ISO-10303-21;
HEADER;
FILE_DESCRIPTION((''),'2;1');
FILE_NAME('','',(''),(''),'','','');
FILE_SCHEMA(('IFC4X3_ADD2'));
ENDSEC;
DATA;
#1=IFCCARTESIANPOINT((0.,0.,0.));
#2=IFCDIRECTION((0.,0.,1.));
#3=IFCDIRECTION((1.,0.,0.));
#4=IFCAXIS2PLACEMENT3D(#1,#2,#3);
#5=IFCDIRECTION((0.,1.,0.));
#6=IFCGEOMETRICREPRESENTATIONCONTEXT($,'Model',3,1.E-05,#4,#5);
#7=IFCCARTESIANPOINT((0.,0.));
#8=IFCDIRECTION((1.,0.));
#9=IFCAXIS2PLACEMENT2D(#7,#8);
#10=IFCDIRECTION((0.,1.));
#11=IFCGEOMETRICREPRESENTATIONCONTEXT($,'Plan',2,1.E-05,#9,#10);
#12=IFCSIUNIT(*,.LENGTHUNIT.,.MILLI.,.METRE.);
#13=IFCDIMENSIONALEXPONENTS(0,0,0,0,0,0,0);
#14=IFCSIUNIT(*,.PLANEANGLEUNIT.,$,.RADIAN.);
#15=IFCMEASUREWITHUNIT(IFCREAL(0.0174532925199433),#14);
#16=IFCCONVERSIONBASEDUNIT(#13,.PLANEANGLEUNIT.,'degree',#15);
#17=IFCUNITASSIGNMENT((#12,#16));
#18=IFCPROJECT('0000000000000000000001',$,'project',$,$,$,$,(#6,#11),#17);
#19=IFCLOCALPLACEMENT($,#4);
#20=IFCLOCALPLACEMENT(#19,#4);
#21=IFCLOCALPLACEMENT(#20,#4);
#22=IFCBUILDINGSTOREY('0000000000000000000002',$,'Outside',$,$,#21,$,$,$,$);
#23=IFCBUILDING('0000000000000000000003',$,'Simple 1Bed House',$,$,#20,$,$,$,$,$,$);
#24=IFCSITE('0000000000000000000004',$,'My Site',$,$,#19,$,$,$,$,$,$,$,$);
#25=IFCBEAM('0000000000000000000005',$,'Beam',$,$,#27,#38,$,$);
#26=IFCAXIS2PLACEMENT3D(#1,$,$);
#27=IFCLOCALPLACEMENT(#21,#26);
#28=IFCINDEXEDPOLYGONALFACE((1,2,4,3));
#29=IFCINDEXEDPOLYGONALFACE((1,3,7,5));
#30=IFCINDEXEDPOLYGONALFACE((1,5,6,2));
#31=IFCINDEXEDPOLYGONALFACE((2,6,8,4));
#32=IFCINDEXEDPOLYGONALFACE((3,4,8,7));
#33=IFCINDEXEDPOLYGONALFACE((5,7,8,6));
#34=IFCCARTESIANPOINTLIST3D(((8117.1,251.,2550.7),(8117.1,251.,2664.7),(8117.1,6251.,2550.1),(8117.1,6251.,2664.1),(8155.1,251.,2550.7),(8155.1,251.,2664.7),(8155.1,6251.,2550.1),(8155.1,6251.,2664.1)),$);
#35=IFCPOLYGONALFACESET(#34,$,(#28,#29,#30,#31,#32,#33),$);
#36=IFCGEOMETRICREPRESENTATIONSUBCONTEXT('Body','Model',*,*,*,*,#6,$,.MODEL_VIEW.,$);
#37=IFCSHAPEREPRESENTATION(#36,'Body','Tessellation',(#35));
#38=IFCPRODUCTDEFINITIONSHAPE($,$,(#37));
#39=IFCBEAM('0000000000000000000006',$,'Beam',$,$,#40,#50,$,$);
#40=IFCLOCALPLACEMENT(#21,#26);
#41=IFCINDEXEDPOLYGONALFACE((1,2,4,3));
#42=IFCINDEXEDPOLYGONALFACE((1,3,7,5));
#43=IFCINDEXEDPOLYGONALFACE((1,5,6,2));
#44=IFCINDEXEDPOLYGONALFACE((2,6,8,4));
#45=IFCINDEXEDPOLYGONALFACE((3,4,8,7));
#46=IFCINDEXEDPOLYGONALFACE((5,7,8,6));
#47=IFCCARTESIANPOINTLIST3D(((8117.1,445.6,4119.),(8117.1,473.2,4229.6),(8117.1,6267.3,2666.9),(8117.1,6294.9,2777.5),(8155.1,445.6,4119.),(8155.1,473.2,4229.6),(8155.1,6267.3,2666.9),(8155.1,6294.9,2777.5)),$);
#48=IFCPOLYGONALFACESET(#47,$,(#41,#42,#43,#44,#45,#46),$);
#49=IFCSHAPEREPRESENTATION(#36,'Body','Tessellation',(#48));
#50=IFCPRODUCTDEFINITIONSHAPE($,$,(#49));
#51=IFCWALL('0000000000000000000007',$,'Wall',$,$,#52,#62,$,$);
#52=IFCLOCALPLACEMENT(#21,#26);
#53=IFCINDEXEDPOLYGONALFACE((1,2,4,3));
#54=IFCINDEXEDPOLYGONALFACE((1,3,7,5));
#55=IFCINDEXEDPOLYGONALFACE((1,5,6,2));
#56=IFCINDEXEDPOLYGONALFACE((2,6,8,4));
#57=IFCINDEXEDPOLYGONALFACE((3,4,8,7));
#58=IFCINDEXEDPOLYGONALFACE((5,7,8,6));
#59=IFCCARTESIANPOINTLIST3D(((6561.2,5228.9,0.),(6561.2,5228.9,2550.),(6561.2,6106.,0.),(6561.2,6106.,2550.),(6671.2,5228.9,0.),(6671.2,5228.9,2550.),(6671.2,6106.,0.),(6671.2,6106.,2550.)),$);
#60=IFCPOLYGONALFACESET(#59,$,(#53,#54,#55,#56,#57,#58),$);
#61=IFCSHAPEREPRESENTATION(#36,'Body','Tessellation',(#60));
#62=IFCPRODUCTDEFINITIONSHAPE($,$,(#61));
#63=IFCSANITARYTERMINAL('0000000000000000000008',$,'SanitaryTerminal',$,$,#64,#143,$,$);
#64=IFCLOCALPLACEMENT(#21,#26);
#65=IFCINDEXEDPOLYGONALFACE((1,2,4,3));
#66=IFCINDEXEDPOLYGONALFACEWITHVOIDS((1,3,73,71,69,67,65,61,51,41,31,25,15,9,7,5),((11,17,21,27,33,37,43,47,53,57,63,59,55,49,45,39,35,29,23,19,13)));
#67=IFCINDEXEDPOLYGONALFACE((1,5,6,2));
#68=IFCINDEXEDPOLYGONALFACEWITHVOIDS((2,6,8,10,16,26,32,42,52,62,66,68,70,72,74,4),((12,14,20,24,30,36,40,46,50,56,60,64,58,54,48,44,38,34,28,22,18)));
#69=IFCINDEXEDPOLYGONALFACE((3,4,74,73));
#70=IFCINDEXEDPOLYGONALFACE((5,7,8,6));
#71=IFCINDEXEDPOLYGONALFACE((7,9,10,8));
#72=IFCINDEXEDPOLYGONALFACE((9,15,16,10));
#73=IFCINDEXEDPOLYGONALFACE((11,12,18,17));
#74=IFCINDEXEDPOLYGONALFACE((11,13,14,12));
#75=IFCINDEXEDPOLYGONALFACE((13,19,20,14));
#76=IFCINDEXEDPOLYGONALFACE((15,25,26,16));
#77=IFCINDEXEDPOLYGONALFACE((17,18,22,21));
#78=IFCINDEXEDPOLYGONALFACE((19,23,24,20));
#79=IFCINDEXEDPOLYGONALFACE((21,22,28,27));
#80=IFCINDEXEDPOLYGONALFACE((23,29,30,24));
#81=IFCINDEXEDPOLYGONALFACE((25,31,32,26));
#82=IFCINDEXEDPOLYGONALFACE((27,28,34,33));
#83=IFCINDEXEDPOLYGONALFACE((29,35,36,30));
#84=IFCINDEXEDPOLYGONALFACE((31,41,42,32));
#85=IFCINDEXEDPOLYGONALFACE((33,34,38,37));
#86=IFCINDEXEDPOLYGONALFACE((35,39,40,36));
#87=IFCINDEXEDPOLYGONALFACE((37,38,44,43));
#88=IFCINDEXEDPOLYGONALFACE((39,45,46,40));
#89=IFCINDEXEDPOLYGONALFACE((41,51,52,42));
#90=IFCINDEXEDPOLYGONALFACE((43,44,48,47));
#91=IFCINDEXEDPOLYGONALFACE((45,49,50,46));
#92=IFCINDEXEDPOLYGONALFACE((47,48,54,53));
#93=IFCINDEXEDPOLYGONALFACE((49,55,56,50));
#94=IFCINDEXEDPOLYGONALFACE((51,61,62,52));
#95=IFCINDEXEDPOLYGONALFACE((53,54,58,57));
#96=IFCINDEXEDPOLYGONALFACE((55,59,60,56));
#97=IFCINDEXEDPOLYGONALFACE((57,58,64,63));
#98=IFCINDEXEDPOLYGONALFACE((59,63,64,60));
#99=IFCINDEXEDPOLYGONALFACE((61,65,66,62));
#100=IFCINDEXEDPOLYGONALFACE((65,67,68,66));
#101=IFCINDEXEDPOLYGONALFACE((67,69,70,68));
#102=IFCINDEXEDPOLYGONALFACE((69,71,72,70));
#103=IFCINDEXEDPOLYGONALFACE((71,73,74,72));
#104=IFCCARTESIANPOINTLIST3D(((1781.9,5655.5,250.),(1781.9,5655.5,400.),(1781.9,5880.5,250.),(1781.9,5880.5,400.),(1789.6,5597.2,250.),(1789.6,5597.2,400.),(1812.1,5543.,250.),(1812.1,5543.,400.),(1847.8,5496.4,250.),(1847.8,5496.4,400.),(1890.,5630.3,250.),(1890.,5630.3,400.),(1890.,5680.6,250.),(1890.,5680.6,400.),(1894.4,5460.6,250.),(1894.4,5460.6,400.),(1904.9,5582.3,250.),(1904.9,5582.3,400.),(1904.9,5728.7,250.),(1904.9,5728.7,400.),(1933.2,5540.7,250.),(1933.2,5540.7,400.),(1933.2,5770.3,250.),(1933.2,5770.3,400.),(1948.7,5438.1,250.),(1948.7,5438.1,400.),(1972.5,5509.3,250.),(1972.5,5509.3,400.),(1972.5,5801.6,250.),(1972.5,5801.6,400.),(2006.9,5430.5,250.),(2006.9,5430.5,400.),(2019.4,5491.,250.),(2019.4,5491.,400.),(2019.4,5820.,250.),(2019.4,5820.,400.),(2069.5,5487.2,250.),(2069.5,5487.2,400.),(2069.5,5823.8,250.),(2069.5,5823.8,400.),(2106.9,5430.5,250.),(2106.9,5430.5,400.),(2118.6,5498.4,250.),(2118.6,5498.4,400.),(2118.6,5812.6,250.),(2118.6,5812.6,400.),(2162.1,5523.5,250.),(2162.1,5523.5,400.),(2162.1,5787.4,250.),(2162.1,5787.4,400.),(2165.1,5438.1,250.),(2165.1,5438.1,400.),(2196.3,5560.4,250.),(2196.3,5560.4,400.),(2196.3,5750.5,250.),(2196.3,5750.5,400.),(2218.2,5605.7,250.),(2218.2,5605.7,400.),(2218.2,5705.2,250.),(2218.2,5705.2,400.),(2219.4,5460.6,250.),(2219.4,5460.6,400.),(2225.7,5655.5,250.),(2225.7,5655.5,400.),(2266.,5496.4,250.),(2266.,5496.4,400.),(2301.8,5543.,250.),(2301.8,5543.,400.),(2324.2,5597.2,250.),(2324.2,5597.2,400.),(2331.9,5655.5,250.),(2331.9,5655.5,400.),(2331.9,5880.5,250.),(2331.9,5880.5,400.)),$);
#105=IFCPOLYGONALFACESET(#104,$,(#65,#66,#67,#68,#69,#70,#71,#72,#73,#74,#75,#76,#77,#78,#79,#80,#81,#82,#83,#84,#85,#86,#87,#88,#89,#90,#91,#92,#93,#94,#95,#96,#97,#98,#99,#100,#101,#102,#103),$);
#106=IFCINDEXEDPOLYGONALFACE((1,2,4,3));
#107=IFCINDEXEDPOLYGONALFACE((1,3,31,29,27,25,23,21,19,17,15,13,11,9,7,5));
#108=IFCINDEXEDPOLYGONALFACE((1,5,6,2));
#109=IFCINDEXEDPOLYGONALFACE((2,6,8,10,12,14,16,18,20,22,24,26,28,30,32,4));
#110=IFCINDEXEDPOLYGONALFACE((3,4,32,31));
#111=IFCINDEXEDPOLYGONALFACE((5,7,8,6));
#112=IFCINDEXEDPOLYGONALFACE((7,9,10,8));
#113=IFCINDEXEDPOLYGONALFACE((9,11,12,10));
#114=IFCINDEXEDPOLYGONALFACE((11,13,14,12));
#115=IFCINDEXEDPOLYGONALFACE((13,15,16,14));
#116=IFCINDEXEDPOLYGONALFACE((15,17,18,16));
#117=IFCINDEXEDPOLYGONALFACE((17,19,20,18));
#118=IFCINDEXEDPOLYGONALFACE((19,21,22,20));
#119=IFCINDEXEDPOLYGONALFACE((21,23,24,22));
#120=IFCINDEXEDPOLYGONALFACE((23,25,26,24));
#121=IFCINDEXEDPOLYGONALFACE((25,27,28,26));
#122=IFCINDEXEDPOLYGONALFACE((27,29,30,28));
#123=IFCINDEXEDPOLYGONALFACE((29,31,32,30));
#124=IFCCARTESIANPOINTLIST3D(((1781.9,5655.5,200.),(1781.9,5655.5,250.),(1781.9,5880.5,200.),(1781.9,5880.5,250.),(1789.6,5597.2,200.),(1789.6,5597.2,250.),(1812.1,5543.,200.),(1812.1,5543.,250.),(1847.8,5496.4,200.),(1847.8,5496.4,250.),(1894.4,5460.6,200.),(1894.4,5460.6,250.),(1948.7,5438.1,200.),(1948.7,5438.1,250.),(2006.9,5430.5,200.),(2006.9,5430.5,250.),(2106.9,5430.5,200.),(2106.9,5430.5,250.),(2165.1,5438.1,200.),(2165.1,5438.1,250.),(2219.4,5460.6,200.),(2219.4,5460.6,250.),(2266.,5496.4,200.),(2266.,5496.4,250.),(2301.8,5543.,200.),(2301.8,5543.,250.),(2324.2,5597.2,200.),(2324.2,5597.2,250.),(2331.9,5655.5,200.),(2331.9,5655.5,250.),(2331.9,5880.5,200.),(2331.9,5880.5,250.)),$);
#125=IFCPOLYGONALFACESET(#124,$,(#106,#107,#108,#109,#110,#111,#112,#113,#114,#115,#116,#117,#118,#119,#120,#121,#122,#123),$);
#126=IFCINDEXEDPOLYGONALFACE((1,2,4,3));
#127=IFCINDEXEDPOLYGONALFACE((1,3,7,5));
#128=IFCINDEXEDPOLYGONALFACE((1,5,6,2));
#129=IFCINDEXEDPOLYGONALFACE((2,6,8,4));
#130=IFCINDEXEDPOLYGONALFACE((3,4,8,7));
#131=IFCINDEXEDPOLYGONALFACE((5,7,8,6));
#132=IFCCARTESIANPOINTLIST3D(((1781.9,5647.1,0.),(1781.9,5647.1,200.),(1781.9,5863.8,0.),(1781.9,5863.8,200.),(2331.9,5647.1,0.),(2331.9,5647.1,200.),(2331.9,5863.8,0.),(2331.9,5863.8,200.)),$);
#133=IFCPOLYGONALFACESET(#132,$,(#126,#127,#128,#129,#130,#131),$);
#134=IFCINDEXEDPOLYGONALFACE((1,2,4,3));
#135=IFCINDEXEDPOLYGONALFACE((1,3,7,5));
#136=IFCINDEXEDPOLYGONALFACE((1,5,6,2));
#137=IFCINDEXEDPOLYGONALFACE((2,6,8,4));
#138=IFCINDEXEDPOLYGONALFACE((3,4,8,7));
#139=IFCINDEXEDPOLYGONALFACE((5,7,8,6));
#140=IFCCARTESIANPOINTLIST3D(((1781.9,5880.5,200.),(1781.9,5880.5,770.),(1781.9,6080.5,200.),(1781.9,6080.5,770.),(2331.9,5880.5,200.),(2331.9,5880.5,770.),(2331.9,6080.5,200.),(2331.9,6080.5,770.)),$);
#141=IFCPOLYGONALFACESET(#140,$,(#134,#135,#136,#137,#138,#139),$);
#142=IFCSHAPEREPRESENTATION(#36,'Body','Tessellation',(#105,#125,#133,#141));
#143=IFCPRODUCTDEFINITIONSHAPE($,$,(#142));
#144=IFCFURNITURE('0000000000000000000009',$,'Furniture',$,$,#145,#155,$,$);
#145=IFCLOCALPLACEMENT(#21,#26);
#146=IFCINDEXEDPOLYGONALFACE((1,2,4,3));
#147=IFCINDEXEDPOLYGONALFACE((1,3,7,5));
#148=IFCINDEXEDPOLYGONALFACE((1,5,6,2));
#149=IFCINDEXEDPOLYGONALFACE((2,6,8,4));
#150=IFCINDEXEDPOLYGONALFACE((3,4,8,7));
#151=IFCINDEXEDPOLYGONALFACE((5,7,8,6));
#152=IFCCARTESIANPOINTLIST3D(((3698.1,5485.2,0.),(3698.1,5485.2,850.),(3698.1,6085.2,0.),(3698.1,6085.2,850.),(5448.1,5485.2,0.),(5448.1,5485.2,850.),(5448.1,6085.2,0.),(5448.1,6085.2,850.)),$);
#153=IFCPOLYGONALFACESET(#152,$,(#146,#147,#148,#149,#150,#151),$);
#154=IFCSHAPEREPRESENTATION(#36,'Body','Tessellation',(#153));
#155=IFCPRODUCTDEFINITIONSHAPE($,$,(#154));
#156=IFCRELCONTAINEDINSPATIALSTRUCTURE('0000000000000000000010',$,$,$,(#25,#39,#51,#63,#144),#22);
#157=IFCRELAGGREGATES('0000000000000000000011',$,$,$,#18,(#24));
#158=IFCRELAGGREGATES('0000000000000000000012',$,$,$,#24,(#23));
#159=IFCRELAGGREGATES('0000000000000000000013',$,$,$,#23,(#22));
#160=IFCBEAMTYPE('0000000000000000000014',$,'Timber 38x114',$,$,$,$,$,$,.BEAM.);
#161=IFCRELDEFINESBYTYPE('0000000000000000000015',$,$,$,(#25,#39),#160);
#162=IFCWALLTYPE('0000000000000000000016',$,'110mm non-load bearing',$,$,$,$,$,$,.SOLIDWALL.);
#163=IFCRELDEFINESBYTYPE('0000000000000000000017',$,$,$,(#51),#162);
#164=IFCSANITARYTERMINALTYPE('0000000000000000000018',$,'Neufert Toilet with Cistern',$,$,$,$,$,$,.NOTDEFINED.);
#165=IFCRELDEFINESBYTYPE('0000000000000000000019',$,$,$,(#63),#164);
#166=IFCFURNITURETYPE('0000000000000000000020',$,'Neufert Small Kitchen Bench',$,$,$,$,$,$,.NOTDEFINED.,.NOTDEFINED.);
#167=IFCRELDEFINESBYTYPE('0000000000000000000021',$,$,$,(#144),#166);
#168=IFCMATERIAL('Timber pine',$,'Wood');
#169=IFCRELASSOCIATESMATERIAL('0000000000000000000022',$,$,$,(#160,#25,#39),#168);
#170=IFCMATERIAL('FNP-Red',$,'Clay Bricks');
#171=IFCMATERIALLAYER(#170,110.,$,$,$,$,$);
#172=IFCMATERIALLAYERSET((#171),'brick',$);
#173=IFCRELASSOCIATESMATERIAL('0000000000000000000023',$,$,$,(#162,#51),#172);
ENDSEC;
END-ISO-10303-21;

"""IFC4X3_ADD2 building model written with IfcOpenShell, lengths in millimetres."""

from ifc_helpers import new_model, entity, si_unit, converted_unit, direction, frame, frame_2d, origin_with_axes, origin_2d_with_axis, place, context, subcontext, project, spatial, line, arc, indexed_curve, circle_curve, rectangle, outline, extrude, shape, source, transform, mapped, material, layer, layer_set, layer_usage, material_profile, profile_set, profile_usage, type_object, type_shapes, element, save


model = new_model("IFC4X3_ADD2")

# Units and contexts
model_context = context("Model", 3, precision=1e-05, world=origin_with_axes(), true_north=direction((0.0, 1.0, 0.0)))
plan_context = context("Plan", 2, precision=1e-05, world=origin_2d_with_axis(), true_north=direction((0.0, 1.0)))
body_context_1 = subcontext(model_context, "Body", "Model", "MODEL_VIEW")
body_context_2 = subcontext(plan_context, "Body", "Plan", "PLAN_VIEW")
ifc_project = project(units=[si_unit("LENGTHUNIT", "METRE", prefix="MILLI"), converted_unit("PLANEANGLEUNIT", "degree", entity("IfcReal", 0.0174532925199433), si_unit("PLANEANGLEUNIT", "RADIAN"), dimensions=[0, 0, 0, 0, 0, 0, 0])], contexts=[model_context, plan_context])

# Site, building, storey
site_placement = place(None, origin_with_axes())
site = spatial("IfcSite", under=ifc_project, at=site_placement, Name="My Site")
building_placement = place(site_placement, origin_with_axes())
building = spatial("IfcBuilding", under=site, at=building_placement, Name="Simple 1Bed House")
storey_placement = place(building_placement, origin_with_axes())
storey = spatial("IfcBuildingStorey", under=building, at=storey_placement, Name="Outside")

# Beams
ifc_material_1 = material(Name="Timber pine", Category="Wood")
ifc_material_profile = material_profile(ifc_material_1, rectangle(XDim=38.0, YDim=114.0))
ifc_profile_set = profile_set([ifc_material_profile], Name="timber-material")
ifc_profile_usage_1 = profile_usage(ifc_profile_set, cardinal=5)
beam_type = type_object("IfcBeamType", Name="Timber 38x114", PredefinedType="BEAM", material=ifc_profile_set)
beam_1_placement = place(storey_placement, frame((8136.1, 251.0, 2607.7), z_axis=(0.0, 1.0, -0.000103), x_axis=(-1.0, 0.0, 0.0)))
element("IfcBeam", 1, at=beam_1_placement, inside=storey, type_object=beam_type, material=ifc_profile_usage_1, Name="Beam", context=body_context_1, shape_type="SweptSolid", body=[
    extrude(rectangle(XDim=38.0, YDim=114.0), origin_with_axes(), (0.0, 0.0, 1.0), 6000.0),
])
ifc_profile_usage_2 = profile_usage(ifc_profile_set, cardinal=5)
beam_2_placement = place(storey_placement, frame((8136.1, 459.4, 4174.3), z_axis=(0.0, 0.970271, -0.242022), x_axis=(-1.0, 0.0, 0.0)))
element("IfcBeam", 2, at=beam_2_placement, inside=storey, type_object=beam_type, material=ifc_profile_usage_2, Name="Beam", context=body_context_1, shape_type="SweptSolid", body=[
    extrude(rectangle(XDim=38.0, YDim=114.0), origin_with_axes(), (0.0, 0.0, 1.0), 6000.0),
])

# Shared definitions
ifc_material_2 = material(Name="FNP-Red", Category="Clay Bricks")
ifc_layer = layer(ifc_material_2, 110.0)
ifc_layer_set = layer_set([ifc_layer], Name="brick")
wall_type = type_object("IfcWallType", Name="110mm non-load bearing", PredefinedType="SOLIDWALL", material=ifc_layer_set)

# Wall
ifc_layer_usage_1 = layer_usage(ifc_layer_set, "AXIS2", "POSITIVE", 0.0)
wall_1_placement = place(storey_placement, frame((6561.2, 6106.0, 0.0), z_axis=(0.0, 0.0, 1.0), x_axis=(0.0, -1.0, 0.0)))
element("IfcWall", 3, at=wall_1_placement, inside=storey, type_object=wall_type, material=ifc_layer_usage_1, Name="Wall", context=body_context_1, shape_type="SweptSolid", body=[
    extrude(outline(indexed_curve([(0.0, 0.0), (0.0, 110.0), (877.1, 110.0), (877.1, 0.0), (0.0, 0.0)], self_intersect=False)), origin_with_axes(), (0.0, 0.0, 1.0), 2550.0),
])

# Sanitary terminal
sanitary_terminal_type = type_object("IfcSanitaryTerminalType", Name="Neufert Toilet with Cistern", PredefinedType="NOTDEFINED")
shared_shape_1 = source(origin_with_axes(), body_context_1, "Body", "SweptSolid", [
    extrude(outline(indexed_curve([(-275.0, -200.0), (275.0, -200.0), (275.0, -425.0), (209.1, -584.1), (50.0, -650.0), (-50.0, -650.0), (-209.1, -584.1), (-275.0, -425.0)], segments=[line(1, 2), line(2, 3), arc(3, 4, 5), line(5, 6), arc(6, 7, 8), line(8, 1)]), holes=[circle_curve(frame_2d((0.0, -425.0)), 168.8)]), frame((0.0, 0.0, 250.0), z_axis=(0.0, 0.0, 1.0), x_axis=(1.0, 0.0, 0.0)), (0.0, 0.0, 1.0), 150.0),
    extrude(outline(indexed_curve([(-275.0, -200.0), (275.0, -200.0), (275.0, -425.0), (209.1, -584.1), (50.0, -650.0), (-50.0, -650.0), (-209.1, -584.1), (-275.0, -425.0)], segments=[line(1, 2), line(2, 3), arc(3, 4, 5), line(5, 6), arc(6, 7, 8), line(8, 1)])), frame((0.0, 0.0, 200.0), z_axis=(0.0, 0.0, 1.0), x_axis=(1.0, 0.0, 0.0)), (0.0, 0.0, 1.0), 50.0),
    extrude(outline(indexed_curve([(-275.0, -216.7), (275.0, -216.7), (275.0, -433.3), (-275.0, -433.3)], segments=[line(1, 2, 3, 4, 1)])), origin_with_axes(), (0.0, 0.0, 1.0), 200.0),
    extrude(outline(indexed_curve([(-275.0, 0.0), (275.0, 0.0), (275.0, -200.0), (-275.0, -200.0)], segments=[line(1, 2, 3, 4, 1)])), frame((0.0, 0.0, 200.0), z_axis=(0.0, 0.0, 1.0), x_axis=(1.0, 0.0, 0.0)), (0.0, 0.0, 1.0), 570.0),
])
shared_shape_2 = source(origin_with_axes(), body_context_2, "Body", "Curve2D", [
    entity("IfcIndexedPolyCurve", entity("IfcCartesianPointList2D", [[-275.0, 0.0], [275.0, 0.0], [275.0, -200.0], [-275.0, -200.0]]), [entity("IfcLineIndex", [1, 2, 3, 4, 1])]),
    entity("IfcIndexedPolyCurve", entity("IfcCartesianPointList2D", [[165.0, -200.0], [192.5, -335.0]])),
    entity("IfcTrimmedCurve", entity("IfcEllipse", entity("IfcAxis2Placement2D", entity("IfcCartesianPoint", [0.0, -335.0]), entity("IfcDirection", [1.0, 0.0])), 192.5, 315.0), [entity("IfcCartesianPoint", [-192.5, -335.0])], [entity("IfcCartesianPoint", [192.5, -335.0])], True, "CARTESIAN"),
    entity("IfcIndexedPolyCurve", entity("IfcCartesianPointList2D", [[-165.0, -200.0], [-192.5, -335.0]])),
    entity("IfcEllipse", entity("IfcAxis2Placement2D", entity("IfcCartesianPoint", [0.0, -452.0]), entity("IfcDirection", [1.0, 0.0])), 131.2, 157.5),
    entity("IfcIndexedPolyCurve", entity("IfcCartesianPointList2D", [[-34.4, -452.0], [-34.4, -429.5], [34.4, -429.5], [34.4, -452.0]])),
    entity("IfcTrimmedCurve", entity("IfcEllipse", entity("IfcAxis2Placement2D", entity("IfcCartesianPoint", [0.0, -452.0]), entity("IfcDirection", [1.0, 0.0])), 34.4, 22.5), [entity("IfcCartesianPoint", [-34.4, -452.0])], [entity("IfcCartesianPoint", [34.4, -452.0])], True, "CARTESIAN"),
])
type_shapes(sanitary_terminal_type, [shared_shape_1, shared_shape_2])
sanitary_terminal_placement = place(storey_placement, frame((2056.9, 6080.5, 0.0), z_axis=(0.0, 0.0, 1.0), x_axis=(1.0, 0.0, 0.0)))
element("IfcSanitaryTerminal", 4, at=sanitary_terminal_placement, inside=storey, type_object=sanitary_terminal_type, Name="SanitaryTerminal", shapes=[
    shape(body_context_1, "Body", "MappedRepresentation", [mapped(shared_shape_1, transform((0.0, 0.0, 0.0), x_axis=(1.0, 0.0, 0.0), y_axis=(0.0, 1.0, 0.0), z_axis=(0.0, 0.0, 1.0), scale=1.0))]),
    shape(body_context_2, "Body", "MappedRepresentation", [mapped(shared_shape_2, transform((0.0, 0.0, 0.0), x_axis=(1.0, 0.0, 0.0), y_axis=(0.0, 1.0, 0.0), z_axis=(0.0, 0.0, 1.0), scale=1.0))]),
])

# Furniture
furniture_type = type_object("IfcFurnitureType", Name="Neufert Small Kitchen Bench", AssemblyPlace="NOTDEFINED", PredefinedType="NOTDEFINED")
shared_shape_3 = source(origin_with_axes(), body_context_1, "Body", "SweptSolid", [
    extrude(outline(indexed_curve([(0.0, 0.0), (1750.0, 0.0), (1750.0, 600.0), (0.0, 600.0)], segments=[line(1, 2, 3, 4, 1)])), origin_with_axes(), (0.0, 0.0, 1.0), 850.0),
])
shared_shape_4 = source(origin_with_axes(), body_context_2, "Body", "Curve2D", [
    entity("IfcIndexedPolyCurve", entity("IfcCartesianPointList2D", [[0.0, 0.0], [1750.0, 0.0], [1750.0, 600.0], [0.0, 600.0]]), [entity("IfcLineIndex", [1, 2, 3, 4, 1])]),
])
type_shapes(furniture_type, [shared_shape_3, shared_shape_4])
furniture_placement = place(storey_placement, frame((3698.1, 5485.2, 0.0), z_axis=(0.0, 0.0, 1.0), x_axis=(1.0, 0.0, 0.0)))
element("IfcFurniture", 5, at=furniture_placement, inside=storey, type_object=furniture_type, Name="Furniture", shapes=[
    shape(body_context_1, "Body", "MappedRepresentation", [mapped(shared_shape_3, transform((0.0, 0.0, 0.0), x_axis=(1.0, 0.0, 0.0), y_axis=(0.0, 1.0, 0.0), z_axis=(0.0, 0.0, 1.0), scale=1.0))]),
    shape(body_context_2, "Body", "MappedRepresentation", [mapped(shared_shape_4, transform((0.0, 0.0, 0.0), x_axis=(1.0, 0.0, 0.0), y_axis=(0.0, 1.0, 0.0), z_axis=(0.0, 0.0, 1.0), scale=1.0))]),
])

save(model, "model.ifc")
